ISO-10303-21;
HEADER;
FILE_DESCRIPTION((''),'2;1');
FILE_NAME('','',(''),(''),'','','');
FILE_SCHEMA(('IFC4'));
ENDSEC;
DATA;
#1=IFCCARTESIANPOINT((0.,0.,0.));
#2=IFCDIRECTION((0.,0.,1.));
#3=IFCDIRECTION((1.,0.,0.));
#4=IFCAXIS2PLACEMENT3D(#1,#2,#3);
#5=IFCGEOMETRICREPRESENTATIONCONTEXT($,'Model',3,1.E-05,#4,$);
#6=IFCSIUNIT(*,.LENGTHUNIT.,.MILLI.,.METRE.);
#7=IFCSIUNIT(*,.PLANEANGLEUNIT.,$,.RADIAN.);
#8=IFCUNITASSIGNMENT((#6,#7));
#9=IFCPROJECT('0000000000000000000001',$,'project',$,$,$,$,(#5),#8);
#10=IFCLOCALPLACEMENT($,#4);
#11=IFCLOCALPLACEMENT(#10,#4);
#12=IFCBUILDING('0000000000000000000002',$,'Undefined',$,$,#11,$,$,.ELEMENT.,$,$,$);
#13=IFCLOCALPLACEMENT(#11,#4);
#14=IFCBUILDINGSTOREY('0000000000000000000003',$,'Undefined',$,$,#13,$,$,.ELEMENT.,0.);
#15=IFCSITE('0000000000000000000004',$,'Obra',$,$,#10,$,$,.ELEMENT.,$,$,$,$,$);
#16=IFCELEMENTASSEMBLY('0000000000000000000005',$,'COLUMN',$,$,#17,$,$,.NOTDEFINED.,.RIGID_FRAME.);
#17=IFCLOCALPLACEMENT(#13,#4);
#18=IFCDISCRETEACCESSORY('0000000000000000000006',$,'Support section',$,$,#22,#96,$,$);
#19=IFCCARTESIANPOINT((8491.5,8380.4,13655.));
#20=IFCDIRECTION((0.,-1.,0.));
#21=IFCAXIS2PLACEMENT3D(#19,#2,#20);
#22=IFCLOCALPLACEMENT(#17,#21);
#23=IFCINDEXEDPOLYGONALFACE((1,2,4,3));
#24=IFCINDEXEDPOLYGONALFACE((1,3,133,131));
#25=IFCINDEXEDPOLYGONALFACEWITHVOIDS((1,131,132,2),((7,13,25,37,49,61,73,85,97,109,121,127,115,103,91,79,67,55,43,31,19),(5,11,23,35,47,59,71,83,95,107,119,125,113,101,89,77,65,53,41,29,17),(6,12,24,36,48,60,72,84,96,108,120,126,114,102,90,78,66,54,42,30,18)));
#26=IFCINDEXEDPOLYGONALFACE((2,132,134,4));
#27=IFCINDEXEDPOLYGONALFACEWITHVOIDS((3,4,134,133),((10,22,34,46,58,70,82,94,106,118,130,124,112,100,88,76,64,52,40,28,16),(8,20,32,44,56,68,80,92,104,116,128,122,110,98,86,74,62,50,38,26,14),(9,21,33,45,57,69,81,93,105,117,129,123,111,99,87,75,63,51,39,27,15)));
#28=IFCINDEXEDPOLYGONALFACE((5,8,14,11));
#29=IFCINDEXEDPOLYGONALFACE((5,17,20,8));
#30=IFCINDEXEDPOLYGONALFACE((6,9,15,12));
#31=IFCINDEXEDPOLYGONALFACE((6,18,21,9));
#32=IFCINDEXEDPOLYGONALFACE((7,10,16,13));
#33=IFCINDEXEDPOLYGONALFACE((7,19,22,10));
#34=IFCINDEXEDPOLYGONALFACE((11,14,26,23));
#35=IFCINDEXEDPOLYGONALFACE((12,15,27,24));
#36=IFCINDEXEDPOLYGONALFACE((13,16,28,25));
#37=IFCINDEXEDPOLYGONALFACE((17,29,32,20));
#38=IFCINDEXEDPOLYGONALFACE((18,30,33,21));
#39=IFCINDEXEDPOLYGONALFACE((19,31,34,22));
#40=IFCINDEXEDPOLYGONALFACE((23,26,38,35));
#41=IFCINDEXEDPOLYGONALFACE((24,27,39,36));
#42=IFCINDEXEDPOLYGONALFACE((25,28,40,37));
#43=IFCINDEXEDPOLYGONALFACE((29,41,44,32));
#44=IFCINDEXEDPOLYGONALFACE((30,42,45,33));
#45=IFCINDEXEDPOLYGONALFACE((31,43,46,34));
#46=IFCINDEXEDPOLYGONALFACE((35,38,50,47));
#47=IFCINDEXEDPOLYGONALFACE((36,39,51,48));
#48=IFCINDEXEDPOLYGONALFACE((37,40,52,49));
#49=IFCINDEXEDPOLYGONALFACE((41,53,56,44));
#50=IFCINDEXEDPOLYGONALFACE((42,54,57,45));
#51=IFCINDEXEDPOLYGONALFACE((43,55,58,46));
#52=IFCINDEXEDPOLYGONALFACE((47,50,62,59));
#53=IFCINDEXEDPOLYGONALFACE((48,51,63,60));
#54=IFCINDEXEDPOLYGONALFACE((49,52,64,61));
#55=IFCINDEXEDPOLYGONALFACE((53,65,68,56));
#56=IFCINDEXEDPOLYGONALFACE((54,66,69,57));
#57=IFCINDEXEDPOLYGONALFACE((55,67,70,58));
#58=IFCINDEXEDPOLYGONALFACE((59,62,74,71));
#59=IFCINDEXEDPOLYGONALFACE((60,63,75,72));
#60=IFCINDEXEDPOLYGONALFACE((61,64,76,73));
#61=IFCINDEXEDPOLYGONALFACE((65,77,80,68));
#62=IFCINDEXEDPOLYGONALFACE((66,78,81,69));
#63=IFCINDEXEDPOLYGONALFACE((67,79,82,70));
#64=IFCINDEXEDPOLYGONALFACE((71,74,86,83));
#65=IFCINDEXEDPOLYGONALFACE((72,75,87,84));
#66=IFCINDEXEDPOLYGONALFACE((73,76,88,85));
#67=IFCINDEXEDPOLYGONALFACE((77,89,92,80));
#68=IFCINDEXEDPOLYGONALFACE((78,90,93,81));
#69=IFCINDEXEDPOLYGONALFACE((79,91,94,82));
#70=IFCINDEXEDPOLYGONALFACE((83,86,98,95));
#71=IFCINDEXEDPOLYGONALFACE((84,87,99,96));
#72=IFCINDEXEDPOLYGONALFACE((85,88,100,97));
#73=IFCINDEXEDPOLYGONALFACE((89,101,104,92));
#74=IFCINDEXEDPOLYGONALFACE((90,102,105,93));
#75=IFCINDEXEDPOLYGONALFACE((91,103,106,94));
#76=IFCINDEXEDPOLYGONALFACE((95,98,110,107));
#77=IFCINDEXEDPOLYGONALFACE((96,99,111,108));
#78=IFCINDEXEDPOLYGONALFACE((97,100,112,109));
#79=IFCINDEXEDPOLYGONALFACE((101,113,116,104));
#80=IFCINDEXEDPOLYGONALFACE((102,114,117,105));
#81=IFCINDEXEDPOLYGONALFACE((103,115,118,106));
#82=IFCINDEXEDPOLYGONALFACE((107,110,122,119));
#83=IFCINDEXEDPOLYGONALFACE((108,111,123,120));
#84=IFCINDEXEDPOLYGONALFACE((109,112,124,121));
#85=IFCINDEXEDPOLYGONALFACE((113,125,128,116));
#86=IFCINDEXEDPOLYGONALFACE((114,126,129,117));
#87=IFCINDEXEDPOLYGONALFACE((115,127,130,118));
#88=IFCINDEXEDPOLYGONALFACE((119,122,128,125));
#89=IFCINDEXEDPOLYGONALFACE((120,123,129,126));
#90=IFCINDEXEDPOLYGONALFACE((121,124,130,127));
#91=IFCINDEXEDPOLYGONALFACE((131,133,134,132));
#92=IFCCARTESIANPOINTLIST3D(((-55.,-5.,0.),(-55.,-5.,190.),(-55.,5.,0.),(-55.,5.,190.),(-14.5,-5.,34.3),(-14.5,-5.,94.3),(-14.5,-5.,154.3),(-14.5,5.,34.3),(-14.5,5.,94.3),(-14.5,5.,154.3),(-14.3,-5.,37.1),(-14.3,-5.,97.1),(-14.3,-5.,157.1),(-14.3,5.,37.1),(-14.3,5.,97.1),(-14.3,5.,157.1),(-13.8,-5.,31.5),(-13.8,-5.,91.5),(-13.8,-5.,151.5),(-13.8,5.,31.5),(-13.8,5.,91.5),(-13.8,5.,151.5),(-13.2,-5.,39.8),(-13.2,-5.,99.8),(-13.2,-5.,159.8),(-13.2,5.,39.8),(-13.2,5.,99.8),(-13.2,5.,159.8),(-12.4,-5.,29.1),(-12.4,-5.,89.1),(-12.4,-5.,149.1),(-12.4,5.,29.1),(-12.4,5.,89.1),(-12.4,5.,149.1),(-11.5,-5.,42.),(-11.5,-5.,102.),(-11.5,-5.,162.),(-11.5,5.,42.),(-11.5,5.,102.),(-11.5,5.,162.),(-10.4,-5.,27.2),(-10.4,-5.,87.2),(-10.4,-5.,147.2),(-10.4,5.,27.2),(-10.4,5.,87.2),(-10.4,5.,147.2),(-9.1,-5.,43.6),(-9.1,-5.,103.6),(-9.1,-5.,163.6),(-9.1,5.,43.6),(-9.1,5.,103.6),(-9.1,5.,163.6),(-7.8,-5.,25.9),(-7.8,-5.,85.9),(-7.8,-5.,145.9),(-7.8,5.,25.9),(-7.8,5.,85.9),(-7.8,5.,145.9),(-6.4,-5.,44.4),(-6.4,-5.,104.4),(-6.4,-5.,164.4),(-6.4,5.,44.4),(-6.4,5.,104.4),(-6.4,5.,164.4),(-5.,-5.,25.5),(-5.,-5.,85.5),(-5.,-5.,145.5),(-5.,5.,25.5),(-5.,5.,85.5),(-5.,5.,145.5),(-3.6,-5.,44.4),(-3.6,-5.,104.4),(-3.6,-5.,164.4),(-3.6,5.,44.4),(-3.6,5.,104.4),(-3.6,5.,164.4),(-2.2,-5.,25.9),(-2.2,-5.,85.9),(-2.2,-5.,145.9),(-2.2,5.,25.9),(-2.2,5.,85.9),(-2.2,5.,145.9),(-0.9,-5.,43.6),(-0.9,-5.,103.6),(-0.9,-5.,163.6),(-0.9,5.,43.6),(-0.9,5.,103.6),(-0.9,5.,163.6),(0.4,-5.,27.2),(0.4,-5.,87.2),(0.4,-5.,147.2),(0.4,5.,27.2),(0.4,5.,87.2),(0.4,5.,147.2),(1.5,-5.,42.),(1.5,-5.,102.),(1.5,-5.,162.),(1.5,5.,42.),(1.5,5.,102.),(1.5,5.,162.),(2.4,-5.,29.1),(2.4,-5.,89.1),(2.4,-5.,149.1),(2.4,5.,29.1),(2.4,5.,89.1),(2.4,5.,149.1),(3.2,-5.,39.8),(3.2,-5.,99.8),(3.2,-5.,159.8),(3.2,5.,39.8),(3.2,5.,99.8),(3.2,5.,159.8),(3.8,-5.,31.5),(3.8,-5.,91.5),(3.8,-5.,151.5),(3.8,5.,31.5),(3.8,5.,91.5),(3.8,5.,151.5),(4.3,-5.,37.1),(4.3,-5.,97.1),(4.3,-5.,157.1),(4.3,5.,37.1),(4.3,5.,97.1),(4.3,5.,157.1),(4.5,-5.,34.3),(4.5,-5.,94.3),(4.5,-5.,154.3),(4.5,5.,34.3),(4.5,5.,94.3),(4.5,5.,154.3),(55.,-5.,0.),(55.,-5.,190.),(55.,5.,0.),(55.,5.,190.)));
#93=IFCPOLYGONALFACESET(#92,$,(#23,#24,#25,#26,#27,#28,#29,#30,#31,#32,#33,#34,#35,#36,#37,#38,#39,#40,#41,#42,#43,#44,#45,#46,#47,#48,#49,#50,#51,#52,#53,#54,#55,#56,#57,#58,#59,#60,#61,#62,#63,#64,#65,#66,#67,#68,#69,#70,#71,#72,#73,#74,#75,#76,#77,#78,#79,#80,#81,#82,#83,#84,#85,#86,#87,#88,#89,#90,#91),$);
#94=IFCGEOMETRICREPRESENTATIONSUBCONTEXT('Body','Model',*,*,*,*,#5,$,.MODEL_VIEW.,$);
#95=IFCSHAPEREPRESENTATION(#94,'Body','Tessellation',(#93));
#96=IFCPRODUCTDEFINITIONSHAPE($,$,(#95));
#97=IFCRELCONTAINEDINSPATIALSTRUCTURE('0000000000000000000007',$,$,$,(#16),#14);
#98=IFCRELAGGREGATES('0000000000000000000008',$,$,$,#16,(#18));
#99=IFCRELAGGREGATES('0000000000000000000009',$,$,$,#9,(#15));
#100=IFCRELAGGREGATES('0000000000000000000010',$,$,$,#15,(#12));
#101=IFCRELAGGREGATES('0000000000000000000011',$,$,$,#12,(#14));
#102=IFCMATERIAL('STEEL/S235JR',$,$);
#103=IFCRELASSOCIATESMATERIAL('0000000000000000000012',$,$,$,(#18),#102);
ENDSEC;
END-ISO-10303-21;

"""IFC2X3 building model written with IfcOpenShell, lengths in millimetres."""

from ifc_helpers import new_model, si_unit, frame, origin_with_axes, origin_2d_with_axis, place, context, subcontext, project, spatial, rectangle, circle, extrude, source, transform, mapped, material, element, aggregate, save


model = new_model("IFC2X3")

# Units and contexts
model_context = context("Model", 3, precision=1e-05, world=origin_with_axes())
body_context = subcontext(model_context, "Body", "Model", "MODEL_VIEW")
ifc_project = project(units=[si_unit("LENGTHUNIT", "METRE", prefix="MILLI"), si_unit("PLANEANGLEUNIT", "RADIAN")], contexts=[model_context])

# Site, building, storey
site_placement = place(None, origin_with_axes())
site = spatial("IfcSite", under=ifc_project, at=site_placement, Name="Obra", CompositionType="ELEMENT")
building_placement = place(site_placement, origin_with_axes())
building = spatial("IfcBuilding", under=site, at=building_placement, Name="Undefined", CompositionType="ELEMENT")
storey_placement = place(building_placement, origin_with_axes())
storey = spatial("IfcBuildingStorey", under=building, at=storey_placement, Name="Undefined", CompositionType="ELEMENT", Elevation=0.0)

# Element assembly
assembly_1_placement = place(storey_placement, origin_with_axes())
assembly_1 = element("IfcElementAssembly", 1, at=assembly_1_placement, inside=storey, Name="COLUMN", AssemblyPlace="NOTDEFINED", PredefinedType="RIGID_FRAME")
ifc_material_1 = material(Name="STEEL/S235JR")

# Discrete accessory, opening
discrete_accessory_1_placement = place(assembly_1_placement, frame((8491.5, 8380.4, 13655.0), z_axis=(0.0, 0.0, 1.0), x_axis=(0.0, -1.0, 0.0)))
discrete_accessory_1 = element("IfcDiscreteAccessory", 2, at=discrete_accessory_1_placement, material=ifc_material_1, Name="Support section", context=body_context, shape_type="SweptSolid", body=[
    extrude(rectangle(XDim=10.0, YDim=110.0, at=origin_2d_with_axis()), frame((0.0, 0.0, 190.0), z_axis=(0.0, 0.0, -1.0), x_axis=(0.0, 1.0, 0.0)), (0.0, 0.0, 1.0), 190.0),
])
shared_shape_1 = source(origin_with_axes(), body_context, "Body", "SweptSolid", [
    extrude(circle(Radius=9.5, at=origin_2d_with_axis()), frame((0.0, 3.4, 0.0), z_axis=(0.0, 1.0, 0.0), x_axis=(1.0, 0.0, 0.0)), (0.0, 0.0, 1.0), 10.2),
])
opening_1_placement = place(assembly_1_placement, frame((8500.0, 8335.4, 13900.0), z_axis=(0.0, 1.0, 0.0), x_axis=(0.0, 0.0, -1.0)))
element("IfcOpeningElement", 3, at=opening_1_placement, cuts=discrete_accessory_1, ObjectType="Opening", context=body_context, shape_type="MappedRepresentation", body=[
    mapped(shared_shape_1, transform((90.0, 0.0, 50.0))),
    mapped(shared_shape_1, transform((150.0, 0.0, 50.0))),
    mapped(shared_shape_1, transform((210.0, 0.0, 50.0))),
])
aggregate(assembly_1, [discrete_accessory_1])

save(model, "model.ifc")
